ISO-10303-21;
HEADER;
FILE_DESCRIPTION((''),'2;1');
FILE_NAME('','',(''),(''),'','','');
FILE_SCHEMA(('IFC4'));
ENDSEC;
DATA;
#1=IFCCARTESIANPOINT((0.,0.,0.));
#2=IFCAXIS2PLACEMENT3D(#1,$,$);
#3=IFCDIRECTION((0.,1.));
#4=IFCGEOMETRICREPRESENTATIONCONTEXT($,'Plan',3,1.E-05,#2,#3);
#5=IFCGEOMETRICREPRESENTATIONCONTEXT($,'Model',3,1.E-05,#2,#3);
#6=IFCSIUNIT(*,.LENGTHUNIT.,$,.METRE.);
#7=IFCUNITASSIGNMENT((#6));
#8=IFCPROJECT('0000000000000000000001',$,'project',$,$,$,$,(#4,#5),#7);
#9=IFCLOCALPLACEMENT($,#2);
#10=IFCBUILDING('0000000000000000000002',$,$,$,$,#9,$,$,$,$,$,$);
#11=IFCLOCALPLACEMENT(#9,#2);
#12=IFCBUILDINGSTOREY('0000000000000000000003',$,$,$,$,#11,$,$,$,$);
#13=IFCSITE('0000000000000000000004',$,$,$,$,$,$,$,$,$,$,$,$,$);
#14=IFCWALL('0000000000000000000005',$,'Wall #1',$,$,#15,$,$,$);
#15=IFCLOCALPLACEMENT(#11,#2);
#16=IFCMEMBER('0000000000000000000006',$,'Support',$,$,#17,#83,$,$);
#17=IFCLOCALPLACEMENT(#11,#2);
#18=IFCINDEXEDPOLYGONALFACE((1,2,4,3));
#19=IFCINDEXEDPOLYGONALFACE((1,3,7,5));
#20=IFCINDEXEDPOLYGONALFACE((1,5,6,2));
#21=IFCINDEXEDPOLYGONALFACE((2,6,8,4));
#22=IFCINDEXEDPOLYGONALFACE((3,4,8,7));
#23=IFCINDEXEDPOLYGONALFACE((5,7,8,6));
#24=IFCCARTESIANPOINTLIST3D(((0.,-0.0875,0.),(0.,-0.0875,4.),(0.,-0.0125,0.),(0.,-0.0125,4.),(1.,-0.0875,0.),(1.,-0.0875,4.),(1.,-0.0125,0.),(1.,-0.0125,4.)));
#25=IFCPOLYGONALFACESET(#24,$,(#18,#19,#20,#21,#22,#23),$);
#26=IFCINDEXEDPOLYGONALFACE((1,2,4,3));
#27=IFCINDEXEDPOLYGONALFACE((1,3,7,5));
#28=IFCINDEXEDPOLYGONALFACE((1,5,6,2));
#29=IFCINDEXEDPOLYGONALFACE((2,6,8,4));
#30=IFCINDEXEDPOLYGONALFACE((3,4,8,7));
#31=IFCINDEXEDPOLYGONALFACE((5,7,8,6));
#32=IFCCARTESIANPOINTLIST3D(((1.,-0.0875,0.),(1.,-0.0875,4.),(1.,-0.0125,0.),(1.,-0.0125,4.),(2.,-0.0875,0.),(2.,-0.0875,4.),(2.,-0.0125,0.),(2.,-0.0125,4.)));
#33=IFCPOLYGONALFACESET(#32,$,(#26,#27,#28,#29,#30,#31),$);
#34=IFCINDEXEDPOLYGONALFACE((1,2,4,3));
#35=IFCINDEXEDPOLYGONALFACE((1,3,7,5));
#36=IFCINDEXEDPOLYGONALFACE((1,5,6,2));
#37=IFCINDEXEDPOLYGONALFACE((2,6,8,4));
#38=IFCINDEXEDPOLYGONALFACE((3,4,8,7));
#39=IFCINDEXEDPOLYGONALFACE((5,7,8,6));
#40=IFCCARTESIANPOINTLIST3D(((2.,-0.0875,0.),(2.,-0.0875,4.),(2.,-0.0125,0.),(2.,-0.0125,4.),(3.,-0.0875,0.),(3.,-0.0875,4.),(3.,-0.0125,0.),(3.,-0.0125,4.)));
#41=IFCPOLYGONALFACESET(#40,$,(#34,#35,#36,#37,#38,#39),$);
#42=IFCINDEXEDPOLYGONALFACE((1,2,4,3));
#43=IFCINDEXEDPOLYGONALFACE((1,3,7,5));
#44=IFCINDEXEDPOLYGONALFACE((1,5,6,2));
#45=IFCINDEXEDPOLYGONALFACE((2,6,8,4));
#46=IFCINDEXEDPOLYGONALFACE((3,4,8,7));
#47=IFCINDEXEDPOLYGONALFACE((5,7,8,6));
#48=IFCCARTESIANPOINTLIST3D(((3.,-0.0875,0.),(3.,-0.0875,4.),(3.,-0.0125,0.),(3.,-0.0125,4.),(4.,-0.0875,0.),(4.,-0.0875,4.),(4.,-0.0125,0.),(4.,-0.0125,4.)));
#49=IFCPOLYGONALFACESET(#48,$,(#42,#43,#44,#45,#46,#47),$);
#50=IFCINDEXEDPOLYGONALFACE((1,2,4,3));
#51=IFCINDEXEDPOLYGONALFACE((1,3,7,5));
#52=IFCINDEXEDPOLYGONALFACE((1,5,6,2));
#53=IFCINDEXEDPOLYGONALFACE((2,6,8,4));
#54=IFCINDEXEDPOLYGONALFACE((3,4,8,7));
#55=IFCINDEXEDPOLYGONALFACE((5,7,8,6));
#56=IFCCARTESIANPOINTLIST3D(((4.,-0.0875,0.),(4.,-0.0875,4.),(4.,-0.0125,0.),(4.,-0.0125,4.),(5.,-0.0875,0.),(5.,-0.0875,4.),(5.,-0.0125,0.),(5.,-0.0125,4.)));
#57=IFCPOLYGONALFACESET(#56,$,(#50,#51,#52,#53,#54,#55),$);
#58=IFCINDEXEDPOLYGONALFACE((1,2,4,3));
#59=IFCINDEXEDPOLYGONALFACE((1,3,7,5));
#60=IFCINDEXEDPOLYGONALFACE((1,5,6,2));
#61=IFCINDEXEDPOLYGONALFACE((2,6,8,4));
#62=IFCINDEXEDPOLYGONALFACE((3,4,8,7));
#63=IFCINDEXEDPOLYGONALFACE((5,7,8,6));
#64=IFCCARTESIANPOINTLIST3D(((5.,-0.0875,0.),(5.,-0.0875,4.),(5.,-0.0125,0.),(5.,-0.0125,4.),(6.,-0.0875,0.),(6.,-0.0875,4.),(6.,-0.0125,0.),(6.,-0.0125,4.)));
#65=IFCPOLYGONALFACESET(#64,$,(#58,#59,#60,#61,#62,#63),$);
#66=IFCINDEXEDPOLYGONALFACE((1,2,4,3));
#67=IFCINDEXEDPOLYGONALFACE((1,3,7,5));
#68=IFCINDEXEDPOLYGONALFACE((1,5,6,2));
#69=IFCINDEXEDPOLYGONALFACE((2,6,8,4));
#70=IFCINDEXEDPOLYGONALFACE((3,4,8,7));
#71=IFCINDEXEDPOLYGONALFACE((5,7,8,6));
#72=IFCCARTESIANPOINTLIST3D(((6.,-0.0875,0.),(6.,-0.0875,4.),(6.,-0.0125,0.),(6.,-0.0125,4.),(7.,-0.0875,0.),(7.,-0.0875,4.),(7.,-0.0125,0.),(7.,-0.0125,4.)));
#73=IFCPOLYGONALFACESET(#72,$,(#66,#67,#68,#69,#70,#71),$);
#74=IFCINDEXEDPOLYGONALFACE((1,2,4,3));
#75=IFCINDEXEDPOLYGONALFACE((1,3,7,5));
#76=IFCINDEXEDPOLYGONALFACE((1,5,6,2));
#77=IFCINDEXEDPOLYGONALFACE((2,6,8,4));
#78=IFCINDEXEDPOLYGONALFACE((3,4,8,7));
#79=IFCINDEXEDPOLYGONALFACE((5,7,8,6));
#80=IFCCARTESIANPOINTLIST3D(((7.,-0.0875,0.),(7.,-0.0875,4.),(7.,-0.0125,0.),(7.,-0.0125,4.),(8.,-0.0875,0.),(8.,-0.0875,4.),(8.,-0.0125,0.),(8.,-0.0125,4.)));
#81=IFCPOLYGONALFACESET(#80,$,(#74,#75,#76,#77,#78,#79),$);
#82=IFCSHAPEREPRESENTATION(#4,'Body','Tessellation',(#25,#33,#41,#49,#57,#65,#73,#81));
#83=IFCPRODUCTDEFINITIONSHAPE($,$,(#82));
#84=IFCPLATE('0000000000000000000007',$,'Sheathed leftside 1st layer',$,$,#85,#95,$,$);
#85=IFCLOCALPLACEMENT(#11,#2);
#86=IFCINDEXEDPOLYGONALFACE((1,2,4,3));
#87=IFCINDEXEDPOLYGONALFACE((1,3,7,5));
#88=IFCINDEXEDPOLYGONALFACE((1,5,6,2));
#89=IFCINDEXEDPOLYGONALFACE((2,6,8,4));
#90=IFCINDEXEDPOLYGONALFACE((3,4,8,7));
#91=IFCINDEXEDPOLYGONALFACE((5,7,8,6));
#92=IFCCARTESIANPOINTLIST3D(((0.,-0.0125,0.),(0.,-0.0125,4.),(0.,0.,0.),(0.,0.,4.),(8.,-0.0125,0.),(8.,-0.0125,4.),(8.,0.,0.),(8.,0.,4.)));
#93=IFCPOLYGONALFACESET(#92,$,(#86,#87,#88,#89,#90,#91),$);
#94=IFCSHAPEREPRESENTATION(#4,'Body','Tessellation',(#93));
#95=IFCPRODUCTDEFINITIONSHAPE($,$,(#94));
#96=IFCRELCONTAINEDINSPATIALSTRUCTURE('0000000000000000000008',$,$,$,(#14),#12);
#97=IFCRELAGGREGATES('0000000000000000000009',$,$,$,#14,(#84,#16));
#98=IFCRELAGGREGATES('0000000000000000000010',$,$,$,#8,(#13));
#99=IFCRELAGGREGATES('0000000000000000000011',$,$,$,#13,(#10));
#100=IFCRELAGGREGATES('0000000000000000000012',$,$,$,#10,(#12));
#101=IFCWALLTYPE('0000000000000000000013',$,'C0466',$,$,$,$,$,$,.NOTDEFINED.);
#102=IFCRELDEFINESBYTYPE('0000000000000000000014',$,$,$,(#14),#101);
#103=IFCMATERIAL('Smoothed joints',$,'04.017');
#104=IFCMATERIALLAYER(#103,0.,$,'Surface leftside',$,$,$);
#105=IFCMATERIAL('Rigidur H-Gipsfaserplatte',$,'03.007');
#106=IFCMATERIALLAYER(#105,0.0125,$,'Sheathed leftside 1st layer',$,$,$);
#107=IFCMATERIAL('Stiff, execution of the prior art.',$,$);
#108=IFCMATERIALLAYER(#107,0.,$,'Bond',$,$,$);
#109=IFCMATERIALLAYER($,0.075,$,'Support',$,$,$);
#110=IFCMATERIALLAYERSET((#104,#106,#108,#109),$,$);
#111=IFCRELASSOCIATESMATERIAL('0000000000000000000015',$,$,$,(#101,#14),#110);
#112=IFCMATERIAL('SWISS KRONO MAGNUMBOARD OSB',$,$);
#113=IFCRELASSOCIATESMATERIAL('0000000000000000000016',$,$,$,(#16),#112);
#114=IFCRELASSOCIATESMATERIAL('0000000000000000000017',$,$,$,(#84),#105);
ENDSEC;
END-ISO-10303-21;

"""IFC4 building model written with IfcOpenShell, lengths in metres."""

from ifc_helpers import new_model, si_unit, direction, frame, frame_2d, origin, origin_with_axes, place, context, project, spatial, rectangle, extrude, material, layer, layer_set, type_object, element, aggregate, save


model = new_model("IFC4")

# Units and contexts
plan_context = context("Plan", 3, precision=1e-05, world=origin(), true_north=direction((0.0, 1.0)))
model_context = context("Model", 3, precision=1e-05, world=origin(), true_north=direction((0.0, 1.0)))
ifc_project = project(units=[si_unit("LENGTHUNIT", "METRE")], contexts=[plan_context, model_context])

# Site, building, storey
site = spatial("IfcSite", under=ifc_project)
building_placement = place(None, origin())
building = spatial("IfcBuilding", under=site, at=building_placement)
storey_placement = place(building_placement, origin())
storey = spatial("IfcBuildingStorey", under=building, at=storey_placement)

# Wall, member, plate
ifc_material_1 = material(Name="Smoothed joints", Category="04.017")
ifc_layer_1 = layer(ifc_material_1, 0.0, Name="Surface leftside")
ifc_material_2 = material(Name="Rigidur H-Gipsfaserplatte", Category="03.007")
ifc_layer_2 = layer(ifc_material_2, 0.0125, Name="Sheathed leftside 1st layer")
ifc_material_3 = material(Name="Stiff, execution of the prior art.")
ifc_layer_3 = layer(ifc_material_3, 0.0, Name="Bond")
ifc_layer_4 = layer(None, 0.075, Name="Support")
ifc_layer_set = layer_set([ifc_layer_1, ifc_layer_2, ifc_layer_3, ifc_layer_4])
wall_type = type_object("IfcWallType", Name="C0466", PredefinedType="NOTDEFINED", material=ifc_layer_set)
wall_placement = place(None, frame((0.0, 0.0, 0.0), z_axis=(0.0, -1.0, 0.0), x_axis=(1.0, 0.0, 0.0)))
wall = element("IfcWall", 1, at=wall_placement, inside=storey, type_object=wall_type, material=ifc_layer_set, Name="Wall #1")
ifc_material_4 = material(Name="SWISS KRONO MAGNUMBOARD OSB")
member_placement = place(wall_placement, origin())
member = element("IfcMember", 2, at=member_placement, material=ifc_material_4, Name="Support", context=plan_context, shape_type="SweptSolid", body=[
    extrude(rectangle(XDim=1.0, YDim=0.075, at=frame_2d((0.5, 0.0375), x_axis=(1.0, 0.0))), frame((0.0, 4.0, 0.0125), z_axis=(0.0, -1.0, 0.0), x_axis=(1.0, 0.0, 0.0)), (0.0, 0.0, 1.0), 4.0),
    extrude(rectangle(XDim=1.0, YDim=0.075, at=frame_2d((0.5, 0.0375), x_axis=(1.0, 0.0))), frame((1.0, 4.0, 0.0125), z_axis=(0.0, -1.0, 0.0), x_axis=(1.0, 0.0, 0.0)), (0.0, 0.0, 1.0), 4.0),
    extrude(rectangle(XDim=1.0, YDim=0.075, at=frame_2d((0.5, 0.0375), x_axis=(1.0, 0.0))), frame((2.0, 4.0, 0.0125), z_axis=(0.0, -1.0, 0.0), x_axis=(1.0, 0.0, 0.0)), (0.0, 0.0, 1.0), 4.0),
    extrude(rectangle(XDim=1.0, YDim=0.075, at=frame_2d((0.5, 0.0375), x_axis=(1.0, 0.0))), frame((3.0, 4.0, 0.0125), z_axis=(0.0, -1.0, 0.0), x_axis=(1.0, 0.0, 0.0)), (0.0, 0.0, 1.0), 4.0),
    extrude(rectangle(XDim=1.0, YDim=0.075, at=frame_2d((0.5, 0.0375), x_axis=(1.0, 0.0))), frame((4.0, 4.0, 0.0125), z_axis=(0.0, -1.0, 0.0), x_axis=(1.0, 0.0, 0.0)), (0.0, 0.0, 1.0), 4.0),
    extrude(rectangle(XDim=1.0, YDim=0.075, at=frame_2d((0.5, 0.0375), x_axis=(1.0, 0.0))), frame((5.0, 4.0, 0.0125), z_axis=(0.0, -1.0, 0.0), x_axis=(1.0, 0.0, 0.0)), (0.0, 0.0, 1.0), 4.0),
    extrude(rectangle(XDim=1.0, YDim=0.075, at=frame_2d((0.5, 0.0375), x_axis=(1.0, 0.0))), frame((6.0, 4.0, 0.0125), z_axis=(0.0, -1.0, 0.0), x_axis=(1.0, 0.0, 0.0)), (0.0, 0.0, 1.0), 4.0),
    extrude(rectangle(XDim=1.0, YDim=0.075, at=frame_2d((0.5, 0.0375), x_axis=(1.0, 0.0))), frame((7.0, 4.0, 0.0125), z_axis=(0.0, -1.0, 0.0), x_axis=(1.0, 0.0, 0.0)), (0.0, 0.0, 1.0), 4.0),
])
plate_placement = place(wall_placement, origin())
plate = element("IfcPlate", 3, at=plate_placement, material=ifc_material_2, Name="Sheathed leftside 1st layer", context=plan_context, shape_type="SweptSolid", body=[
    extrude(rectangle(XDim=8.0, YDim=4.0, at=frame_2d((4.0, 2.0), x_axis=(1.0, 0.0))), origin_with_axes(), (0.0, 0.0, 1.0), 0.0125),
])
aggregate(wall, [plate, member])

save(model, "model.ifc")
